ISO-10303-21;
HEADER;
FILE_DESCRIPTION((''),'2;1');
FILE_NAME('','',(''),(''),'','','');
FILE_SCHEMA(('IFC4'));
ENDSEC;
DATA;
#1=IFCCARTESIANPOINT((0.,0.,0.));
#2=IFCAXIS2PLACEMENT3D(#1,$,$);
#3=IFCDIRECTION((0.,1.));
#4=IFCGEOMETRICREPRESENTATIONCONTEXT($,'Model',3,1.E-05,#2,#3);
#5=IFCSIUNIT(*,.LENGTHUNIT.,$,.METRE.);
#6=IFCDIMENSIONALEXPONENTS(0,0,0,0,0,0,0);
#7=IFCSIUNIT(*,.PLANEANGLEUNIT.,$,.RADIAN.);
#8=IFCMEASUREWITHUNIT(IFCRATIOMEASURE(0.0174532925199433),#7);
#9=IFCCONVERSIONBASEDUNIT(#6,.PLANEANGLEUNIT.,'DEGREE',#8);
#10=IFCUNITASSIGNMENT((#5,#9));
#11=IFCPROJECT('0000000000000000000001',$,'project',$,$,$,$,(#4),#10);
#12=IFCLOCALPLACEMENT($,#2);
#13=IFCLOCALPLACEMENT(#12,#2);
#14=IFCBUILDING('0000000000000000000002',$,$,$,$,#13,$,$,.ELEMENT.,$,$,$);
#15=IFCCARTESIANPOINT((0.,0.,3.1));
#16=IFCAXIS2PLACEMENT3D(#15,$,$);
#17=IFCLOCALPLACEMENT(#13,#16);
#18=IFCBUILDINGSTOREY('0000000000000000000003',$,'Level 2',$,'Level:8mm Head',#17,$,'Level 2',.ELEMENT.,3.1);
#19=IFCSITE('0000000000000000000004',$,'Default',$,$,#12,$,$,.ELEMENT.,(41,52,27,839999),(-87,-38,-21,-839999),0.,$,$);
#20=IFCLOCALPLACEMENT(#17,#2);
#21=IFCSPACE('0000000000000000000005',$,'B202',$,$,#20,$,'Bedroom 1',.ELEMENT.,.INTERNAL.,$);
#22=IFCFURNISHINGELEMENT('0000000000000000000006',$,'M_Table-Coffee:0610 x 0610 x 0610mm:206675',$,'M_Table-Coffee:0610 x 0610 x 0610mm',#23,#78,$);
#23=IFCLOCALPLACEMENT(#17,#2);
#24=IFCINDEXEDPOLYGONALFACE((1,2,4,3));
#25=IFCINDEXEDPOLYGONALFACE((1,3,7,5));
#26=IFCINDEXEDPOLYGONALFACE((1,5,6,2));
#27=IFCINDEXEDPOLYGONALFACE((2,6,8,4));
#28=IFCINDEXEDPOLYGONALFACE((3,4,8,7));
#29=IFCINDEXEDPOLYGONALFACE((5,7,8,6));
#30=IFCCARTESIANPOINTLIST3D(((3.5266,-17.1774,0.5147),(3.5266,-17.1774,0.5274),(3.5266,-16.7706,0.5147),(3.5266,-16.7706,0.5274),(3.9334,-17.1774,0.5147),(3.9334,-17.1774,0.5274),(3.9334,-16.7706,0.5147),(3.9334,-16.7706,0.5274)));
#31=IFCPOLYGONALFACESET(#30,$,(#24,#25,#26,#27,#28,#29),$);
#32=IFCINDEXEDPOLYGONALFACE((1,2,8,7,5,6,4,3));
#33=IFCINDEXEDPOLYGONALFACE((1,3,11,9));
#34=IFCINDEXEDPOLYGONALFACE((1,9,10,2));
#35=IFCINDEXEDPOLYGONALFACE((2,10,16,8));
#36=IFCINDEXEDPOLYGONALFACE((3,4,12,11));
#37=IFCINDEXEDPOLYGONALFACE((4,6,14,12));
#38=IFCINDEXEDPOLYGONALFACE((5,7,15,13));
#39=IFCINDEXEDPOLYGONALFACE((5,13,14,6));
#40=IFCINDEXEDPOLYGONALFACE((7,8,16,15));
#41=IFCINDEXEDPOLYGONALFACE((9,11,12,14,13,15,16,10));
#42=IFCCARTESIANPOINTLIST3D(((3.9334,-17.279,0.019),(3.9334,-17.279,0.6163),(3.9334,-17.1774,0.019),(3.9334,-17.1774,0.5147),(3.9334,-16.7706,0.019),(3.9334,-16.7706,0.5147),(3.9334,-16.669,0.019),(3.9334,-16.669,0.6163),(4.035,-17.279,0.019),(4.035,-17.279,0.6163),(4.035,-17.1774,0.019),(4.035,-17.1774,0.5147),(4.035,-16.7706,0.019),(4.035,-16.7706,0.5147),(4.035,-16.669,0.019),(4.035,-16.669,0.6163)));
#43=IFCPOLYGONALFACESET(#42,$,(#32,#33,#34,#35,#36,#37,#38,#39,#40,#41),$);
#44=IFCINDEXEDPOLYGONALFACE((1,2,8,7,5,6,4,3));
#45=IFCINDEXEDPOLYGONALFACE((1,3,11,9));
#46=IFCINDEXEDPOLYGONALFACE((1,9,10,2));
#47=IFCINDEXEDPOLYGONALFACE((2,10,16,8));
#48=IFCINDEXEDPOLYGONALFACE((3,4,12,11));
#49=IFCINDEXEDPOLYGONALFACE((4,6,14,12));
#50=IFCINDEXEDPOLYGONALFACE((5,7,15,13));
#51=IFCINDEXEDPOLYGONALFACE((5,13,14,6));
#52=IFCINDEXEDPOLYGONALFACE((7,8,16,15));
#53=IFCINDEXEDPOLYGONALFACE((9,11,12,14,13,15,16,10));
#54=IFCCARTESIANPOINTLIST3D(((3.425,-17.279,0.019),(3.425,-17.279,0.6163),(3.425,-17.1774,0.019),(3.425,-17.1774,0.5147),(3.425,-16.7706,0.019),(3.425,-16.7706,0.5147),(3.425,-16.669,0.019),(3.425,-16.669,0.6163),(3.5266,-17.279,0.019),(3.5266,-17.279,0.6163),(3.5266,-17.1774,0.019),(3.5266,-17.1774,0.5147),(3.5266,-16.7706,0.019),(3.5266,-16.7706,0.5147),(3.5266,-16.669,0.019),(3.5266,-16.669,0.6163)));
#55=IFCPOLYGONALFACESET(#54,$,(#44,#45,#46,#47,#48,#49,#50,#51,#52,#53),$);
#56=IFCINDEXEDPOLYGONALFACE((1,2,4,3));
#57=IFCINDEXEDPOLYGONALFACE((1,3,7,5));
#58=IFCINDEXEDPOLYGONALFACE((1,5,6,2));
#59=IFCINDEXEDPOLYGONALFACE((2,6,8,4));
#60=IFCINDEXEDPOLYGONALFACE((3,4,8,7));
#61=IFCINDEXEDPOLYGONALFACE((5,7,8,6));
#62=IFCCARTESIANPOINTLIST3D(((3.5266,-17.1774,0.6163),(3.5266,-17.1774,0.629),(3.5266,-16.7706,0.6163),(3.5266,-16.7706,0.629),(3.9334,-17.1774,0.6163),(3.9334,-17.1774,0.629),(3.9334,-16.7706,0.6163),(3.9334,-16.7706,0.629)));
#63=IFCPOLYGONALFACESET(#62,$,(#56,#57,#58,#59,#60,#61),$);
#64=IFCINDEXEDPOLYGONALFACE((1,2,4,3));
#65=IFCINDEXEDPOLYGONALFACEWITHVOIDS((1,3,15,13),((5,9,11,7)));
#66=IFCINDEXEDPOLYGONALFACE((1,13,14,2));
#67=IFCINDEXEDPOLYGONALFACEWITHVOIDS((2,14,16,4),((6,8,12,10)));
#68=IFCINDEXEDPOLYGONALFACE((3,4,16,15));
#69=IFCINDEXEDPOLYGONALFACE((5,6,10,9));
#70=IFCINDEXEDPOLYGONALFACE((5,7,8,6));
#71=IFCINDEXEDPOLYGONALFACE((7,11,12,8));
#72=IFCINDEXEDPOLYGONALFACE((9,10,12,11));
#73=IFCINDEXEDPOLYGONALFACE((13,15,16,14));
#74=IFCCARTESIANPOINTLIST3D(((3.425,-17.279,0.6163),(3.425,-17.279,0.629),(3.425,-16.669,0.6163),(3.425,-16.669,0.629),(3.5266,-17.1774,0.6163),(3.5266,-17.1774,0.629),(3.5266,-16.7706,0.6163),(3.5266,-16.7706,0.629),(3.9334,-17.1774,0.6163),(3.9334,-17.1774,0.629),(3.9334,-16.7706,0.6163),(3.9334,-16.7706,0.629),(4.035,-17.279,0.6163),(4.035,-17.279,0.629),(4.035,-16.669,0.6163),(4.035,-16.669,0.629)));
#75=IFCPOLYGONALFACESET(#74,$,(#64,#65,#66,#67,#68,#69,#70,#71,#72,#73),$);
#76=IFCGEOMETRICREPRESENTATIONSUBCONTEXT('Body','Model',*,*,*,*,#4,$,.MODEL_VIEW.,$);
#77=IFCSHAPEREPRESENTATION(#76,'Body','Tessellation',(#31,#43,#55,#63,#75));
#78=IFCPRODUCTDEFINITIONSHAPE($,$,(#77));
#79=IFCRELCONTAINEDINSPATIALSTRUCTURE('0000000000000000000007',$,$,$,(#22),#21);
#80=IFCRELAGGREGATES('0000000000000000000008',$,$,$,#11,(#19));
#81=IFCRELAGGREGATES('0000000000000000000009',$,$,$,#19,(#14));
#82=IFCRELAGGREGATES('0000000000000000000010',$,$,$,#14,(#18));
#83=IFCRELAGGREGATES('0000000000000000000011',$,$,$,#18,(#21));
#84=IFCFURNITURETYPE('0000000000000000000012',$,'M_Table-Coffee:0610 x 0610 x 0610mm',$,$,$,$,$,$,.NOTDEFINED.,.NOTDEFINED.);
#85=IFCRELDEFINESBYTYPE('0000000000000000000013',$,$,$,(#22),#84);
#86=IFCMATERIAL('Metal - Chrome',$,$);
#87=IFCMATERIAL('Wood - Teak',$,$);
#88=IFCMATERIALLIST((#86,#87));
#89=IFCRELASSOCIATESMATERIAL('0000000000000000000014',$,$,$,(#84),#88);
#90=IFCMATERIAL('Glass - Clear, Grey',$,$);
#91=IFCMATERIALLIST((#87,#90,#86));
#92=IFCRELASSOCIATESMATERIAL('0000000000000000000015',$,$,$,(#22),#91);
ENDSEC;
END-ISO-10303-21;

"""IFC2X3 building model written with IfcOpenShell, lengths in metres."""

from ifc_helpers import new_model, entity, si_unit, converted_unit, direction, frame, origin, origin_2d_with_axis, place, context, subcontext, project, spatial, polyline, rectangle, outline, extrude, source, transform, mapped, material, material_list, type_object, type_shapes, element, save


model = new_model("IFC2X3")

# Units and contexts
model_context = context("Model", 3, precision=1e-05, world=origin(), true_north=direction((0.0, 1.0)))
body_context = subcontext(model_context, "Body", "Model", "MODEL_VIEW")
ifc_project = project(units=[si_unit("LENGTHUNIT", "METRE"), converted_unit("PLANEANGLEUNIT", "DEGREE", entity("IfcRatioMeasure", 0.0174532925199433), si_unit("PLANEANGLEUNIT", "RADIAN"), dimensions=[0, 0, 0, 0, 0, 0, 0])], contexts=[model_context])

# Site, building, storey
site_placement = place(None, origin())
site = spatial("IfcSite", under=ifc_project, at=site_placement, Name="Default", CompositionType="ELEMENT", RefLatitude=(41, 52, 27, 839999), RefLongitude=(-87, -38, -21, -839999), RefElevation=0.0)
building_placement = place(site_placement, origin())
building = spatial("IfcBuilding", under=site, at=building_placement, CompositionType="ELEMENT")
storey_placement = place(building_placement, frame((0.0, 0.0, 3.1)))
storey = spatial("IfcBuildingStorey", under=building, at=storey_placement, Name="Level 2", ObjectType="Level:8mm Head", LongName="Level 2", CompositionType="ELEMENT", Elevation=3.1)

# Shared definitions
space_placement = place(storey_placement, origin())
space = spatial("IfcSpace", under=storey, at=space_placement, Name="B202", LongName="Bedroom 1", CompositionType="ELEMENT", InteriorOrExteriorSpace="INTERNAL")

# Furnishing element
ifc_material_1 = material(Name="Wood - Teak")
ifc_material_2 = material(Name="Glass - Clear, Grey")
ifc_material_3 = material(Name="Metal - Chrome")
ifc_material_list_1 = material_list([ifc_material_1, ifc_material_2, ifc_material_3])
ifc_material_list_2 = material_list([ifc_material_3, ifc_material_1])
furniture_type_1 = type_object("IfcFurnitureType", Name="M_Table-Coffee:0610 x 0610 x 0610mm", material=ifc_material_list_2)
shared_shape_1 = source(origin(), body_context, "Body", "SweptSolid", [
    extrude(rectangle(XDim=0.4068, YDim=0.4068, at=origin_2d_with_axis()), frame((0.0183, 0.0952, 0.4957), z_axis=(0.0, 0.0, 1.0), x_axis=(-1.0, 0.0, 0.0)), (0.0, 0.0, 1.0), 0.0127),
    extrude(outline(polyline([(-0.2732, -0.305), (0.324, -0.305), (0.324, 0.305), (-0.2732, 0.305), (-0.2732, 0.2034), (0.2225, 0.2034), (0.2225, -0.2034), (-0.2732, -0.2034), (-0.2732, -0.305)])), frame((0.2217, 0.0952, 0.2732), z_axis=(1.0, 0.0, 0.0), x_axis=(0.0, 0.0, 1.0)), (0.0, 0.0, 1.0), 0.1016),
    extrude(outline(polyline([(-0.305, -0.3241), (0.305, -0.3241), (0.305, 0.2733), (0.2034, 0.2733), (0.2034, -0.2224), (-0.2034, -0.2224), (-0.2034, 0.2733), (-0.305, 0.2733), (-0.305, -0.3241)])), frame((-0.2867, 0.0952, 0.2733), z_axis=(1.0, 0.0, 0.0), x_axis=(0.0, -1.0, 0.0)), (0.0, 0.0, 1.0), 0.1016),
    extrude(rectangle(XDim=0.4068, YDim=0.4068, at=origin_2d_with_axis()), frame((0.0183, 0.0952, 0.5973), z_axis=(0.0, 0.0, 1.0), x_axis=(-1.0, 0.0, 0.0)), (0.0, 0.0, 1.0), 0.0127),
    extrude(outline(polyline([(-0.305, -0.305), (0.305, -0.305), (0.305, 0.305), (-0.305, 0.305), (-0.305, -0.305)]), holes=[polyline([(-0.2034, -0.2034), (-0.2034, 0.2034), (0.2034, 0.2034), (0.2034, -0.2034), (-0.2034, -0.2034)])]), frame((0.0183, 0.0952, 0.5973), z_axis=(0.0, 0.0, 1.0), x_axis=(-1.0, 0.0, 0.0)), (0.0, 0.0, 1.0), 0.0127),
])
type_shapes(furniture_type_1, [shared_shape_1])
furnishing_1_placement = place(space_placement, frame((3.7117, -17.0692, 0.019)))
element("IfcFurnishingElement", 1, at=furnishing_1_placement, inside=space, type_object=furniture_type_1, material=ifc_material_list_1, Name="M_Table-Coffee:0610 x 0610 x 0610mm:206675", ObjectType="M_Table-Coffee:0610 x 0610 x 0610mm", context=body_context, shape_type="MappedRepresentation", body=[
    mapped(shared_shape_1, transform((0.0, 0.0, 0.0), scale=1.0)),
])

save(model, "model.ifc")
